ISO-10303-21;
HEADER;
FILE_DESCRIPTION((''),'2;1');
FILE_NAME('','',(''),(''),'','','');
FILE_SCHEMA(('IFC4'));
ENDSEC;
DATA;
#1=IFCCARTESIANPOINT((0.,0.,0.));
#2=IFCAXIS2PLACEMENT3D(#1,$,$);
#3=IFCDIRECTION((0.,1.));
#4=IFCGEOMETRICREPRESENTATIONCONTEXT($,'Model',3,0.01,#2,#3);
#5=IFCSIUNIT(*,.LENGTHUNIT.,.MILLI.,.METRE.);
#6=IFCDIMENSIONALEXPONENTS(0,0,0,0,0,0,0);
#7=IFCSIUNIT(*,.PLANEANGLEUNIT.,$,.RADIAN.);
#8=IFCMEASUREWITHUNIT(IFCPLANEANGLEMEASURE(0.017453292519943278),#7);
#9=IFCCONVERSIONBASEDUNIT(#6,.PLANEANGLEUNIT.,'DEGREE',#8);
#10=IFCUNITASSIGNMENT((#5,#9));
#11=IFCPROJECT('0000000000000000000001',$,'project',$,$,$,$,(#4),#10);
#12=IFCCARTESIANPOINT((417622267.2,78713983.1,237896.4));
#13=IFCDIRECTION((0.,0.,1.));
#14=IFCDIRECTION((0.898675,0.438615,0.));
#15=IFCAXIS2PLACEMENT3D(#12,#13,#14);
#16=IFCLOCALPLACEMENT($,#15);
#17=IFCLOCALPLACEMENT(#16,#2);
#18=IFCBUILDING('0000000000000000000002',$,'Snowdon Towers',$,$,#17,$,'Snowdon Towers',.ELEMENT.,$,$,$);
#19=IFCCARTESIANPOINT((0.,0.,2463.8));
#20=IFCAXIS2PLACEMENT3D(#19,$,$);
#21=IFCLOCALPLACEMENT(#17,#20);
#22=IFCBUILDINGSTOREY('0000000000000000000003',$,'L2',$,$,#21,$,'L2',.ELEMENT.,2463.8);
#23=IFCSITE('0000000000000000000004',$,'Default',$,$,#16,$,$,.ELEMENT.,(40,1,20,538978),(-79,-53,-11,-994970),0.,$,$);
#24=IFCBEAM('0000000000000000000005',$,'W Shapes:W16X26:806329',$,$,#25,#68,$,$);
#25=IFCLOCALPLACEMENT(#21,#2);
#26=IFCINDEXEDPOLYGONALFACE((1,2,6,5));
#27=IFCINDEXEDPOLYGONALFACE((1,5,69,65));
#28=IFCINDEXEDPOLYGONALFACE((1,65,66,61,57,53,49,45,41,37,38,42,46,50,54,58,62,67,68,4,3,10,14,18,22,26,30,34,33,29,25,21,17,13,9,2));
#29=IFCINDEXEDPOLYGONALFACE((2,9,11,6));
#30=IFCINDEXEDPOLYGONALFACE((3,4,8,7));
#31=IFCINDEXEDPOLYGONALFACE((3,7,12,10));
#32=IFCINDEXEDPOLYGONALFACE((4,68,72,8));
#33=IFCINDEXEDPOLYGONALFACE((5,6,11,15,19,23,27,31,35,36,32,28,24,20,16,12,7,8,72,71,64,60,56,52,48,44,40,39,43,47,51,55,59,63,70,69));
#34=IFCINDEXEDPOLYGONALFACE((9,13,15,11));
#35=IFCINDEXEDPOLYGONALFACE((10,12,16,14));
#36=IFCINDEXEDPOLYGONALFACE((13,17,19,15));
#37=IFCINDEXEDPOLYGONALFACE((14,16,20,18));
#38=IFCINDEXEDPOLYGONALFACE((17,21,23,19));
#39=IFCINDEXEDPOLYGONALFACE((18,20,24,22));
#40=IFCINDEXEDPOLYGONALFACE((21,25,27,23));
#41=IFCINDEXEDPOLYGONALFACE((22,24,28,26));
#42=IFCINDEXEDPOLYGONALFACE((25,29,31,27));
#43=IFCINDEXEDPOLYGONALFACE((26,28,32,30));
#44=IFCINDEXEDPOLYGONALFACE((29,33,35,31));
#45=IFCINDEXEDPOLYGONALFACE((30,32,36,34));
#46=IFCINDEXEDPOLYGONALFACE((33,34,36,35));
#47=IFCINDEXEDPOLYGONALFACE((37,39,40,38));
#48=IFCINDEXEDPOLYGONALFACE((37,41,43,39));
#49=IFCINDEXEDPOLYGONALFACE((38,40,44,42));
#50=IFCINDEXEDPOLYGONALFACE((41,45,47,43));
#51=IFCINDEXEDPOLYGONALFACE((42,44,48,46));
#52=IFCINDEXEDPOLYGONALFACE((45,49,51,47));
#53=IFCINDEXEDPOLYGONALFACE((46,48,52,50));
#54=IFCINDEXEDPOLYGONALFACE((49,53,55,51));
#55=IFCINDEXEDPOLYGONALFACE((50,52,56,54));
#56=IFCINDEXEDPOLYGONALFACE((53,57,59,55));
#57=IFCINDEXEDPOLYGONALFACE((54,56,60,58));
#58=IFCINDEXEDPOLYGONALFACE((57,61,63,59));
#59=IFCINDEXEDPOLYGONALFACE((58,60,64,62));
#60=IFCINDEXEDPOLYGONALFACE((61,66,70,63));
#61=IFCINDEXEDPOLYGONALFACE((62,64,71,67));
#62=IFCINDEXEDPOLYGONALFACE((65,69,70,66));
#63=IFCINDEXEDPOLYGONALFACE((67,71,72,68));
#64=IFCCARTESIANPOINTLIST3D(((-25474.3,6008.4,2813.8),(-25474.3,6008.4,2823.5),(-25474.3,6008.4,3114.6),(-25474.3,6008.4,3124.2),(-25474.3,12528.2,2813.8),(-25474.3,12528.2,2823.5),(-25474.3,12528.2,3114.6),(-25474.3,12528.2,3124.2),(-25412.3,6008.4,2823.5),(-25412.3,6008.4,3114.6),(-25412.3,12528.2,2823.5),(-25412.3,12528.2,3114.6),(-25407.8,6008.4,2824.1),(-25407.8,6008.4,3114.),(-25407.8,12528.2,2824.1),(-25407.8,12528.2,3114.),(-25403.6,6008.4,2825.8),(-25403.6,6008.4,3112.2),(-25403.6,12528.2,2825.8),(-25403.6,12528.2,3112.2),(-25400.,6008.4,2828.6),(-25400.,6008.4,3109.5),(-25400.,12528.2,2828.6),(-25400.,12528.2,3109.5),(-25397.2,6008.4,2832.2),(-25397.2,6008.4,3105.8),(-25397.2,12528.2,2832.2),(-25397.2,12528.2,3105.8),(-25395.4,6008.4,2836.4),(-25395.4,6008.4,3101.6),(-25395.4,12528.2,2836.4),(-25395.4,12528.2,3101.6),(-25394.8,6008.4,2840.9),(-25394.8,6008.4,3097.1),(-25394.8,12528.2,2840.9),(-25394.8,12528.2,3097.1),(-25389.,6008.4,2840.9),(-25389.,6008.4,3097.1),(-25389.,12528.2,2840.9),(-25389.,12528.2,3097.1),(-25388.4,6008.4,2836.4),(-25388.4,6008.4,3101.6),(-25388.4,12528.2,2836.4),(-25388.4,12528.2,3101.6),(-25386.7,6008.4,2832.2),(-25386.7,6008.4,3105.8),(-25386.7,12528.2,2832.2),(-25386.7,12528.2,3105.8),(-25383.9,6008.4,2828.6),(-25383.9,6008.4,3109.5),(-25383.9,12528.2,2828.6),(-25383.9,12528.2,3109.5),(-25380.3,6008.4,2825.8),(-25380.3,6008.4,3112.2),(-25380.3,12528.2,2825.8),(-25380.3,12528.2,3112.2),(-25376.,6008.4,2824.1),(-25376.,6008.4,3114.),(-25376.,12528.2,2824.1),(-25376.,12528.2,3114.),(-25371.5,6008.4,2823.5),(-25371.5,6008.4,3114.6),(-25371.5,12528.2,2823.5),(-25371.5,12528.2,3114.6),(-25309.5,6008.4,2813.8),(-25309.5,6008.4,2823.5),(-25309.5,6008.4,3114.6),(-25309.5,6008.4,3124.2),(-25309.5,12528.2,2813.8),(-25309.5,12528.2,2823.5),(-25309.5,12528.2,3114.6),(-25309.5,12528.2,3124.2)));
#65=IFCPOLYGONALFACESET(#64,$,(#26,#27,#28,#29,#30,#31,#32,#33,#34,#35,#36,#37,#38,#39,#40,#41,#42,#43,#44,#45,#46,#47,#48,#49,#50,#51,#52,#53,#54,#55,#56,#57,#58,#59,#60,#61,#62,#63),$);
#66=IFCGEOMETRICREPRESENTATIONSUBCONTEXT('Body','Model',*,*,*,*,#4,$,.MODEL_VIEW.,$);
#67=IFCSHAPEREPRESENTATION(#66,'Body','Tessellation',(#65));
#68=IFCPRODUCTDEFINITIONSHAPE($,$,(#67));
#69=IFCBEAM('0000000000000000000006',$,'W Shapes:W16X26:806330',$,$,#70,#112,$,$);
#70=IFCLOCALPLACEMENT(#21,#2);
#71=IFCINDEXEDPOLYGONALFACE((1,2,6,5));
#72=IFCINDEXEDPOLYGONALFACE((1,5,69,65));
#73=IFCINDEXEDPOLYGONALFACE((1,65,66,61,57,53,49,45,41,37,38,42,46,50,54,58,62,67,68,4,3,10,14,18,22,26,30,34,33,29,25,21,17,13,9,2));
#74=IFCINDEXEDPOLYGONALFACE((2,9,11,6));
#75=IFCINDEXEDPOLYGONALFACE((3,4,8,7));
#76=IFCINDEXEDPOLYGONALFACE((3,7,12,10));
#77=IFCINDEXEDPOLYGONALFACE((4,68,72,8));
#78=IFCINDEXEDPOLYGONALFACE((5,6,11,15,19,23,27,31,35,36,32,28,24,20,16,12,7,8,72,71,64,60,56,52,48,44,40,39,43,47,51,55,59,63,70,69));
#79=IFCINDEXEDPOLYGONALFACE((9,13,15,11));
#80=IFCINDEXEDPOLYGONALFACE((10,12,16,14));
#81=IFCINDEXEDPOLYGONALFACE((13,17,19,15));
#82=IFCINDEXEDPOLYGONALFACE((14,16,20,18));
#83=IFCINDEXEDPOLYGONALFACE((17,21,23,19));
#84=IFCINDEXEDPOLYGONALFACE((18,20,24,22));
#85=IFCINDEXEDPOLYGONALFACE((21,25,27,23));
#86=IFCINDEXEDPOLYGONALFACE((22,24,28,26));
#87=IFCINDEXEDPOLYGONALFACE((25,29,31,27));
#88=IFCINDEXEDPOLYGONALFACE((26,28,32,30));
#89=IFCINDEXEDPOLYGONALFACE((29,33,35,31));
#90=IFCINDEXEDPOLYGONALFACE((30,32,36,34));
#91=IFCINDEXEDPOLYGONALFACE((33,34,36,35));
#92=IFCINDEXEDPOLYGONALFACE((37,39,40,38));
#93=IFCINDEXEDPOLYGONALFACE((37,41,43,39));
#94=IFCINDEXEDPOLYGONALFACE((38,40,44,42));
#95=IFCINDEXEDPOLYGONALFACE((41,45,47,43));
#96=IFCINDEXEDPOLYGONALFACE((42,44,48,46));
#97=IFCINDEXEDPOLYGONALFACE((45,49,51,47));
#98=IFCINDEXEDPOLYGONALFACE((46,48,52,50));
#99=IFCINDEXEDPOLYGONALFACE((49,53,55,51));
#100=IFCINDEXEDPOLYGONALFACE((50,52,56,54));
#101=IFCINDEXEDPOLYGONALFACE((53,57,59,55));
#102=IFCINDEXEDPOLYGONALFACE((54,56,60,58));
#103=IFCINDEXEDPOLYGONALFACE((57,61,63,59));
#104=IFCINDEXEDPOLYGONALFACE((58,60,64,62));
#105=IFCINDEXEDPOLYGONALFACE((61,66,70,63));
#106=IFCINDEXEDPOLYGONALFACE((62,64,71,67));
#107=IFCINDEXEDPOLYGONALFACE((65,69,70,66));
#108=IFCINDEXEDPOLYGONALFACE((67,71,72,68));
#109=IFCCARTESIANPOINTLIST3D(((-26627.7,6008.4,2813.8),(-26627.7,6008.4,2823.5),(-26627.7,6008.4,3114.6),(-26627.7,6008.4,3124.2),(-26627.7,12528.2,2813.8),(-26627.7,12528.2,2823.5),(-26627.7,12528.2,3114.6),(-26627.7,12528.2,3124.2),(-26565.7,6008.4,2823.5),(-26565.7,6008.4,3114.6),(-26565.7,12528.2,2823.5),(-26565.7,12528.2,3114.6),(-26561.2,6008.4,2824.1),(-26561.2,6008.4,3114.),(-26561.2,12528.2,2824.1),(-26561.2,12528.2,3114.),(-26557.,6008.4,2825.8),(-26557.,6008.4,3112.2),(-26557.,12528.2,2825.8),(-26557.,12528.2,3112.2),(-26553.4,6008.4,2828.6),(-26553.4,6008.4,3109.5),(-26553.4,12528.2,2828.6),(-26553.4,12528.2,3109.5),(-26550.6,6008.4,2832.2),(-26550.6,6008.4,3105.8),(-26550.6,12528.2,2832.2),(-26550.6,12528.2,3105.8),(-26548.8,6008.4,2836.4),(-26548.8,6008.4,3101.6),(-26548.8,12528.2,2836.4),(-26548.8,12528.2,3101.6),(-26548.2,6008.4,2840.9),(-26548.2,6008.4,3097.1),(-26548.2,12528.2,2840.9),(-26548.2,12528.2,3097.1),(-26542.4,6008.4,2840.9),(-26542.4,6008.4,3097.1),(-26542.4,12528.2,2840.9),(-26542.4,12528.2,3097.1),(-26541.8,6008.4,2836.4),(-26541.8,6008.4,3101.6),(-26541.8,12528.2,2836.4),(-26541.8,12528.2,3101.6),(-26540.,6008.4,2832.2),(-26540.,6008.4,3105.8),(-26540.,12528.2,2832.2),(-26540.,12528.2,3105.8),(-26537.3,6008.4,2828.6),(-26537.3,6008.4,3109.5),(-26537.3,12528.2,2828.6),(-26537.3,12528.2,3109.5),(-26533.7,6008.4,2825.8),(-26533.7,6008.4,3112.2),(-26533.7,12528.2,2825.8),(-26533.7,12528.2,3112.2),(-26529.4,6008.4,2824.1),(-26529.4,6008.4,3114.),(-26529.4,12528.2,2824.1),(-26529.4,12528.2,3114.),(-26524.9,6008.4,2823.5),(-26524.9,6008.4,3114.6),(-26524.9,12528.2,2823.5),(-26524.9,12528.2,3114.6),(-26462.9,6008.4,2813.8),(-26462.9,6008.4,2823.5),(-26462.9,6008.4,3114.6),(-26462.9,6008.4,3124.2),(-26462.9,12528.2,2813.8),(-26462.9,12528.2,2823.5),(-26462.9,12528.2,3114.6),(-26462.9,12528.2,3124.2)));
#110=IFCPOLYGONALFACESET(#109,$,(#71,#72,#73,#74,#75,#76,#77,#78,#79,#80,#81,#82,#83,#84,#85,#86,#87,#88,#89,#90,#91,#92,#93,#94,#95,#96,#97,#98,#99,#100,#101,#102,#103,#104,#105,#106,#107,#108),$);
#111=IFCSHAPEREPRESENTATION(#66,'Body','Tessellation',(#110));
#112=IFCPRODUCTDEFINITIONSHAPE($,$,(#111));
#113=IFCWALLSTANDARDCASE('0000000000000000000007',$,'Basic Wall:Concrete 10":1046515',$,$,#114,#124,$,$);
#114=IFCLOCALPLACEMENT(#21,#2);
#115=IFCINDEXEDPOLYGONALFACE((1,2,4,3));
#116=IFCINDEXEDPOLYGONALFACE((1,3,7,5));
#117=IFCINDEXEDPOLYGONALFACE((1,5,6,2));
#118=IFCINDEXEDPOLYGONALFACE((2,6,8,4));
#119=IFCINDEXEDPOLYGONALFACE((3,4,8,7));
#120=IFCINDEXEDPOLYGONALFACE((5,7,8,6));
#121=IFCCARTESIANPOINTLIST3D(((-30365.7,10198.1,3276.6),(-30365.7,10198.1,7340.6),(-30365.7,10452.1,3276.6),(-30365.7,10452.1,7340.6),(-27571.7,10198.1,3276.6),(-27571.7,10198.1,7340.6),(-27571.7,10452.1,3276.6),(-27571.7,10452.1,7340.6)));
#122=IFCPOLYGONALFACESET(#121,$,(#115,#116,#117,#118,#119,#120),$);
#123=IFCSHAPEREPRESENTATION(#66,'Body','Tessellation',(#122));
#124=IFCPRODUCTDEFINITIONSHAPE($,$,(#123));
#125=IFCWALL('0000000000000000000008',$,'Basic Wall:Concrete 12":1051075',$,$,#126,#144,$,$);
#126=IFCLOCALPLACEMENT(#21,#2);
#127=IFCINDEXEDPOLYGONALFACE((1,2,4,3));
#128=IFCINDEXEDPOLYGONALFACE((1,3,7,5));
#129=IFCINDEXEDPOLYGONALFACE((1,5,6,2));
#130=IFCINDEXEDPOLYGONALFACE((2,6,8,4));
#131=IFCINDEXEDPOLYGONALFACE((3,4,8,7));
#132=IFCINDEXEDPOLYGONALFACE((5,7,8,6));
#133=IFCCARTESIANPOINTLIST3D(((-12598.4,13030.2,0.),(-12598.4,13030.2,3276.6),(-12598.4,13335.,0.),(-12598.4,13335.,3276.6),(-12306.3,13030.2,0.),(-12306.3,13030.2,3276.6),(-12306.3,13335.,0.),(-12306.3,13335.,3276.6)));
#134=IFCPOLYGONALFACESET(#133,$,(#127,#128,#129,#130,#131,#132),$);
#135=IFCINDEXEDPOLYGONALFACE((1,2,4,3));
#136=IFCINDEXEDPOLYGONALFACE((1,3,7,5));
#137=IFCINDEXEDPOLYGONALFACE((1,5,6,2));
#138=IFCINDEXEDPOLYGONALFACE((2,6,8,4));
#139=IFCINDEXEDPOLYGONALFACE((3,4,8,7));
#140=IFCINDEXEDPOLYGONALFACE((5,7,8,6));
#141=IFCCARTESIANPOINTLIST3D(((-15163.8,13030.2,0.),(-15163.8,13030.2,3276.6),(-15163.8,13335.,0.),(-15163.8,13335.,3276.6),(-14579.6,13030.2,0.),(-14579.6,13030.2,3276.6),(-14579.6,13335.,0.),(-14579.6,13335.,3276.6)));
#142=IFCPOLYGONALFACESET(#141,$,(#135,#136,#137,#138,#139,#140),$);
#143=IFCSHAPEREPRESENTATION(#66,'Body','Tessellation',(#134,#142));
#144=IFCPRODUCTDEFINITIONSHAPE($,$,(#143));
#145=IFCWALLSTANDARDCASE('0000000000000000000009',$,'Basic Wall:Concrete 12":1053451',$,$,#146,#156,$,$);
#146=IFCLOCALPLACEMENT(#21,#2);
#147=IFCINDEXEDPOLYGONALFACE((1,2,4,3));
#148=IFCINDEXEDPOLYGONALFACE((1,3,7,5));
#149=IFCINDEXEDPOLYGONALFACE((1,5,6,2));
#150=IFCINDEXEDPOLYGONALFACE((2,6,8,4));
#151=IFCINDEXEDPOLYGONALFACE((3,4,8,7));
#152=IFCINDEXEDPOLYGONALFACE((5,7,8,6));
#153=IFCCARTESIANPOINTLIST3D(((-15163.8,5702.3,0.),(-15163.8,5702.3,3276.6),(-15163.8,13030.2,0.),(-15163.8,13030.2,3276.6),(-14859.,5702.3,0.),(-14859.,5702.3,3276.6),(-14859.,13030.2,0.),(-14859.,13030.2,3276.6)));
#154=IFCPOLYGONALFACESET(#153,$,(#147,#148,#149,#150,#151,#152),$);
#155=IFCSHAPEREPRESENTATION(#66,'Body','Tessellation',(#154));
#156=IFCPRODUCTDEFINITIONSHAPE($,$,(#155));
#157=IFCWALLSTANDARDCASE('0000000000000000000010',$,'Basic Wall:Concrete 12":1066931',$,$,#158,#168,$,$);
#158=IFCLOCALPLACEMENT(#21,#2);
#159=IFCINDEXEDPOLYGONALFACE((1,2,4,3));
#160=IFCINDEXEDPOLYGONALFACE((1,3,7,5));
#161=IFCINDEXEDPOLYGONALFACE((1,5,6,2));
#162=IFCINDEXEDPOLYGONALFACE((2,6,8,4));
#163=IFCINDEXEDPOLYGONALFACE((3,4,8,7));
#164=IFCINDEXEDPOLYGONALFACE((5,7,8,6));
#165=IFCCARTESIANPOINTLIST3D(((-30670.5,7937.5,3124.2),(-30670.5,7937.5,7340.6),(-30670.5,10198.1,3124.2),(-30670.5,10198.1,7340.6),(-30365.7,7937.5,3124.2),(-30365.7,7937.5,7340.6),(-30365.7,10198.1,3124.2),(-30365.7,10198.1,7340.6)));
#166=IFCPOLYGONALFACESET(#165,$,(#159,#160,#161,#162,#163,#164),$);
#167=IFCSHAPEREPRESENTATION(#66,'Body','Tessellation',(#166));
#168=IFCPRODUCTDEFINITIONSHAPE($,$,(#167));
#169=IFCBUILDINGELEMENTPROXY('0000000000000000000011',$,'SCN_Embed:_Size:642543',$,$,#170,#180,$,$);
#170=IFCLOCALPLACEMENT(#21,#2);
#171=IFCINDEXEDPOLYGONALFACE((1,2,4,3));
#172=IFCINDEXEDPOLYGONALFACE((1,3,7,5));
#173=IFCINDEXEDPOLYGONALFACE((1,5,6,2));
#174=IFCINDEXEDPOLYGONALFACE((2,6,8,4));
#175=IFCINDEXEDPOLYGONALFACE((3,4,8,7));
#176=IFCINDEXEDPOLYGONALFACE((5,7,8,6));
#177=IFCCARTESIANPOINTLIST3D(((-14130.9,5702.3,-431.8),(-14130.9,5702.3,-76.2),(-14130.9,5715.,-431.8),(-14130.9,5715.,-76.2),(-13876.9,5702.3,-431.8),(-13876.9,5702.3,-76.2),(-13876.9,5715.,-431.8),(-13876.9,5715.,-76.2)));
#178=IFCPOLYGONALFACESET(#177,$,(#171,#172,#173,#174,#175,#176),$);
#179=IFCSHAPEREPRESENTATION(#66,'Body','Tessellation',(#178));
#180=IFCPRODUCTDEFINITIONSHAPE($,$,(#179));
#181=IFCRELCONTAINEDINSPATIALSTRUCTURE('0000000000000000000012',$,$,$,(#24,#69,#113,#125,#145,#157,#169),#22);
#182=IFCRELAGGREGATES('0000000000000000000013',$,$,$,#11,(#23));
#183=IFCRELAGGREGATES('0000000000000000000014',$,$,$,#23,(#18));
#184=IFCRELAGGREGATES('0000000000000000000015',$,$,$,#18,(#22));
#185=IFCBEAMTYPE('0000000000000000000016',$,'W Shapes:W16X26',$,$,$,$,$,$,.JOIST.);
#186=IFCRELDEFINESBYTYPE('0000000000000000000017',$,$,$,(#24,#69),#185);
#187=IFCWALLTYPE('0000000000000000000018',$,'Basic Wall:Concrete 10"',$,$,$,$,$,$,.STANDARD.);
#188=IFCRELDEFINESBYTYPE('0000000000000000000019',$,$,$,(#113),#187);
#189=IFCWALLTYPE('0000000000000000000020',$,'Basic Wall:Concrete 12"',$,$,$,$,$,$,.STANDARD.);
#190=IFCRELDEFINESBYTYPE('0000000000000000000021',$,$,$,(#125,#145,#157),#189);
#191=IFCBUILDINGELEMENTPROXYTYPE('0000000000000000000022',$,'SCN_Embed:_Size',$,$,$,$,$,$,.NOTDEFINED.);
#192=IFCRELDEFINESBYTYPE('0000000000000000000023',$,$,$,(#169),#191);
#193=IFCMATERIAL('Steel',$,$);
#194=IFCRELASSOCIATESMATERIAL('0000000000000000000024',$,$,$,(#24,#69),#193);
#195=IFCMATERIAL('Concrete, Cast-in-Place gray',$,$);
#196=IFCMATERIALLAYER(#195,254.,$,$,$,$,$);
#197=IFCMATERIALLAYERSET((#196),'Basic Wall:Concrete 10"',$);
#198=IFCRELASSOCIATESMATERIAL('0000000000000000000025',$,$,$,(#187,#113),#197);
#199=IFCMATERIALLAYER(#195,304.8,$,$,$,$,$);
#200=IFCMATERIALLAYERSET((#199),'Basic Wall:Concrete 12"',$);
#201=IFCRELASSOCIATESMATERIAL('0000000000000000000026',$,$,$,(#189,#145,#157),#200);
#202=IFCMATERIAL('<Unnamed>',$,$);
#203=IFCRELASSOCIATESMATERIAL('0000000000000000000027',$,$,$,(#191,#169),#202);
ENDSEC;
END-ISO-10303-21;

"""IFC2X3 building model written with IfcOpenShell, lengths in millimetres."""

from ifc_helpers import new_model, entity, si_unit, converted_unit, direction, frame, frame_2d, origin, place, context, subcontext, project, spatial, rectangle, i_section, extrude, source, transform, mapped, material, layer, layer_set, layer_usage, type_object, type_shapes, element, save


model = new_model("IFC2X3")

# Units and contexts
model_context = context("Model", 3, precision=0.01, world=origin(), true_north=direction((0.0, 1.0)))
body_context = subcontext(model_context, "Body", "Model", "MODEL_VIEW")
ifc_project = project(units=[si_unit("LENGTHUNIT", "METRE", prefix="MILLI"), converted_unit("PLANEANGLEUNIT", "DEGREE", entity("IfcPlaneAngleMeasure", 0.017453292519943278), si_unit("PLANEANGLEUNIT", "RADIAN"), dimensions=[0, 0, 0, 0, 0, 0, 0])], contexts=[model_context])

# Site, building, storey
site_placement = place(None, frame((417622267.2, 78713983.1, 237896.4), z_axis=(0.0, 0.0, 1.0), x_axis=(0.898675, 0.438615, 0.0)))
site = spatial("IfcSite", under=ifc_project, at=site_placement, Name="Default", CompositionType="ELEMENT", RefLatitude=(40, 1, 20, 538978), RefLongitude=(-79, -53, -11, -994970), RefElevation=0.0)
building_placement = place(site_placement, origin())
building = spatial("IfcBuilding", under=site, at=building_placement, Name="Snowdon Towers", LongName="Snowdon Towers", CompositionType="ELEMENT")
storey_placement = place(building_placement, frame((0.0, 0.0, 2463.8)))
storey = spatial("IfcBuildingStorey", under=building, at=storey_placement, Name="L2", LongName="L2", CompositionType="ELEMENT", Elevation=2463.8)

# Beams
ifc_material_1 = material(Name="Steel")
beam_type_1 = type_object("IfcBeamType", Name="W Shapes:W16X26", PredefinedType="JOIST")
beam_1_placement = place(storey_placement, frame((-25391.9, 12636.5, 3124.2), z_axis=(0.0, 0.0, 1.0), x_axis=(0.0, -1.0, 0.0)))
element("IfcBeam", 1, at=beam_1_placement, inside=storey, type_object=beam_type_1, material=ifc_material_1, Name="W Shapes:W16X26:806329", context=body_context, shape_type="SweptSolid", body=[
    extrude(i_section(OverallWidth=164.8, OverallDepth=310.4, WebThickness=5.9, FlangeThickness=9.6, FilletRadius=17.5, at=frame_2d((0.0, 0.0), x_axis=(0.0, 1.0))), frame((108.3, 0.0, -155.2), z_axis=(1.0, 0.0, 0.0), x_axis=(0.0, 0.0, -1.0)), (0.0, 0.0, 1.0), 6519.8),
])
beam_2_placement = place(storey_placement, frame((-26545.3, 12636.5, 3124.2), z_axis=(0.0, 0.0, 1.0), x_axis=(0.0, -1.0, 0.0)))
element("IfcBeam", 2, at=beam_2_placement, inside=storey, type_object=beam_type_1, material=ifc_material_1, Name="W Shapes:W16X26:806330", context=body_context, shape_type="SweptSolid", body=[
    extrude(i_section(OverallWidth=164.8, OverallDepth=310.4, WebThickness=5.9, FlangeThickness=9.6, FilletRadius=17.5, at=frame_2d((0.0, 0.0), x_axis=(0.0, 1.0))), frame((108.3, 0.0, -155.2), z_axis=(1.0, 0.0, 0.0), x_axis=(0.0, 0.0, -1.0)), (0.0, 0.0, 1.0), 6519.8),
])

# Walls
ifc_material_2 = material(Name="Concrete, Cast-in-Place gray")
ifc_layer_1 = layer(ifc_material_2, 254.0)
ifc_layer_set_1 = layer_set([ifc_layer_1], Name="Basic Wall:Concrete 10\"")
ifc_layer_usage_1 = layer_usage(ifc_layer_set_1, "AXIS2", "POSITIVE", -127.0)
wall_type_1 = type_object("IfcWallType", Name="Basic Wall:Concrete 10\"", PredefinedType="STANDARD", material=ifc_layer_set_1)
wall_1_placement = place(storey_placement, frame((-30365.7, 10325.1, 3276.6)))
element("IfcWallStandardCase", 3, at=wall_1_placement, inside=storey, type_object=wall_type_1, material=ifc_layer_usage_1, Name="Basic Wall:Concrete 10\":1046515", context=body_context, shape_type="SweptSolid", body=[
    extrude(rectangle(XDim=2794.0, YDim=254.0, at=frame_2d((1397.0, 0.0), x_axis=(-1.0, 0.0))), origin(), (0.0, 0.0, 1.0), 4064.0),
])
ifc_layer_2 = layer(ifc_material_2, 304.8)
ifc_layer_set_2 = layer_set([ifc_layer_2], Name="Basic Wall:Concrete 12\"")
wall_type_2 = type_object("IfcWallType", Name="Basic Wall:Concrete 12\"", PredefinedType="STANDARD", material=ifc_layer_set_2)
wall_2_placement = place(storey_placement, frame((-12306.3, 13182.6, 0.0), z_axis=(0.0, 0.0, 1.0), x_axis=(-1.0, 0.0, 0.0)))
element("IfcWall", 4, at=wall_2_placement, inside=storey, type_object=wall_type_2, Name="Basic Wall:Concrete 12\":1051075", context=body_context, shape_type="SweptSolid", body=[
    extrude(rectangle(XDim=304.8, YDim=292.1, at=frame_2d((0.0, 0.0), x_axis=(1.0, 0.0))), frame((146.1, 0.0, 0.0), z_axis=(0.0, 0.0, 1.0), x_axis=(0.0, 1.0, 0.0)), (0.0, 0.0, 1.0), 3276.6),
    extrude(rectangle(XDim=304.8, YDim=584.2, at=frame_2d((0.0, -4.2), x_axis=(1.0, 0.0))), frame((2561.2, 0.0, 0.0), z_axis=(0.0, 0.0, 1.0), x_axis=(0.0, 1.0, 0.0)), (0.0, 0.0, 1.0), 3276.6),
])
ifc_layer_usage_2 = layer_usage(ifc_layer_set_2, "AXIS2", "POSITIVE", -152.4)
wall_3_placement = place(storey_placement, frame((-15011.4, 13030.2, 0.0), z_axis=(0.0, 0.0, 1.0), x_axis=(0.0, -1.0, 0.0)))
element("IfcWallStandardCase", 5, at=wall_3_placement, inside=storey, type_object=wall_type_2, material=ifc_layer_usage_2, Name="Basic Wall:Concrete 12\":1053451", context=body_context, shape_type="SweptSolid", body=[
    extrude(rectangle(XDim=7327.9, YDim=304.8, at=frame_2d((3664.0, 0.0), x_axis=(-1.0, 0.0))), origin(), (0.0, 0.0, 1.0), 3276.6),
])
ifc_layer_usage_3 = layer_usage(ifc_layer_set_2, "AXIS2", "POSITIVE", -152.4)
wall_4_placement = place(storey_placement, frame((-30518.1, 7937.5, 3124.2), z_axis=(0.0, 0.0, 1.0), x_axis=(0.0, 1.0, 0.0)))
element("IfcWallStandardCase", 6, at=wall_4_placement, inside=storey, type_object=wall_type_2, material=ifc_layer_usage_3, Name="Basic Wall:Concrete 12\":1066931", context=body_context, shape_type="SweptSolid", body=[
    extrude(rectangle(XDim=2260.6, YDim=304.8, at=frame_2d((1130.3, 0.0), x_axis=(-1.0, 0.0))), origin(), (0.0, 0.0, 1.0), 4216.4),
])

# Building element proxy
ifc_material_3 = material(Name="<Unnamed>")
building_element_proxy_type_1 = type_object("IfcBuildingElementProxyType", Name="SCN_Embed:_Size", PredefinedType="NOTDEFINED", material=ifc_material_3)
shared_shape_1 = source(origin(), body_context, "Body", "SweptSolid", [
    extrude(rectangle(XDim=254.0, YDim=355.6, at=frame_2d((0.0, 0.0), x_axis=(1.0, 0.0))), frame((0.0, 0.0, -12.7), z_axis=(0.0, 0.0, 1.0), x_axis=(-1.0, 0.0, 0.0)), (0.0, 0.0, 1.0), 12.7),
])
type_shapes(building_element_proxy_type_1, [shared_shape_1])
proxy_placement = place(storey_placement, frame((-14003.9, 5702.3, -254.0), z_axis=(0.0, -1.0, 0.0), x_axis=(1.0, 0.0, 0.0)))
element("IfcBuildingElementProxy", 7, at=proxy_placement, inside=storey, type_object=building_element_proxy_type_1, material=ifc_material_3, Name="SCN_Embed:_Size:642543", context=body_context, shape_type="MappedRepresentation", body=[
    mapped(shared_shape_1, transform((0.0, 0.0, 0.0), scale=1.0)),
])

save(model, "model.ifc")
